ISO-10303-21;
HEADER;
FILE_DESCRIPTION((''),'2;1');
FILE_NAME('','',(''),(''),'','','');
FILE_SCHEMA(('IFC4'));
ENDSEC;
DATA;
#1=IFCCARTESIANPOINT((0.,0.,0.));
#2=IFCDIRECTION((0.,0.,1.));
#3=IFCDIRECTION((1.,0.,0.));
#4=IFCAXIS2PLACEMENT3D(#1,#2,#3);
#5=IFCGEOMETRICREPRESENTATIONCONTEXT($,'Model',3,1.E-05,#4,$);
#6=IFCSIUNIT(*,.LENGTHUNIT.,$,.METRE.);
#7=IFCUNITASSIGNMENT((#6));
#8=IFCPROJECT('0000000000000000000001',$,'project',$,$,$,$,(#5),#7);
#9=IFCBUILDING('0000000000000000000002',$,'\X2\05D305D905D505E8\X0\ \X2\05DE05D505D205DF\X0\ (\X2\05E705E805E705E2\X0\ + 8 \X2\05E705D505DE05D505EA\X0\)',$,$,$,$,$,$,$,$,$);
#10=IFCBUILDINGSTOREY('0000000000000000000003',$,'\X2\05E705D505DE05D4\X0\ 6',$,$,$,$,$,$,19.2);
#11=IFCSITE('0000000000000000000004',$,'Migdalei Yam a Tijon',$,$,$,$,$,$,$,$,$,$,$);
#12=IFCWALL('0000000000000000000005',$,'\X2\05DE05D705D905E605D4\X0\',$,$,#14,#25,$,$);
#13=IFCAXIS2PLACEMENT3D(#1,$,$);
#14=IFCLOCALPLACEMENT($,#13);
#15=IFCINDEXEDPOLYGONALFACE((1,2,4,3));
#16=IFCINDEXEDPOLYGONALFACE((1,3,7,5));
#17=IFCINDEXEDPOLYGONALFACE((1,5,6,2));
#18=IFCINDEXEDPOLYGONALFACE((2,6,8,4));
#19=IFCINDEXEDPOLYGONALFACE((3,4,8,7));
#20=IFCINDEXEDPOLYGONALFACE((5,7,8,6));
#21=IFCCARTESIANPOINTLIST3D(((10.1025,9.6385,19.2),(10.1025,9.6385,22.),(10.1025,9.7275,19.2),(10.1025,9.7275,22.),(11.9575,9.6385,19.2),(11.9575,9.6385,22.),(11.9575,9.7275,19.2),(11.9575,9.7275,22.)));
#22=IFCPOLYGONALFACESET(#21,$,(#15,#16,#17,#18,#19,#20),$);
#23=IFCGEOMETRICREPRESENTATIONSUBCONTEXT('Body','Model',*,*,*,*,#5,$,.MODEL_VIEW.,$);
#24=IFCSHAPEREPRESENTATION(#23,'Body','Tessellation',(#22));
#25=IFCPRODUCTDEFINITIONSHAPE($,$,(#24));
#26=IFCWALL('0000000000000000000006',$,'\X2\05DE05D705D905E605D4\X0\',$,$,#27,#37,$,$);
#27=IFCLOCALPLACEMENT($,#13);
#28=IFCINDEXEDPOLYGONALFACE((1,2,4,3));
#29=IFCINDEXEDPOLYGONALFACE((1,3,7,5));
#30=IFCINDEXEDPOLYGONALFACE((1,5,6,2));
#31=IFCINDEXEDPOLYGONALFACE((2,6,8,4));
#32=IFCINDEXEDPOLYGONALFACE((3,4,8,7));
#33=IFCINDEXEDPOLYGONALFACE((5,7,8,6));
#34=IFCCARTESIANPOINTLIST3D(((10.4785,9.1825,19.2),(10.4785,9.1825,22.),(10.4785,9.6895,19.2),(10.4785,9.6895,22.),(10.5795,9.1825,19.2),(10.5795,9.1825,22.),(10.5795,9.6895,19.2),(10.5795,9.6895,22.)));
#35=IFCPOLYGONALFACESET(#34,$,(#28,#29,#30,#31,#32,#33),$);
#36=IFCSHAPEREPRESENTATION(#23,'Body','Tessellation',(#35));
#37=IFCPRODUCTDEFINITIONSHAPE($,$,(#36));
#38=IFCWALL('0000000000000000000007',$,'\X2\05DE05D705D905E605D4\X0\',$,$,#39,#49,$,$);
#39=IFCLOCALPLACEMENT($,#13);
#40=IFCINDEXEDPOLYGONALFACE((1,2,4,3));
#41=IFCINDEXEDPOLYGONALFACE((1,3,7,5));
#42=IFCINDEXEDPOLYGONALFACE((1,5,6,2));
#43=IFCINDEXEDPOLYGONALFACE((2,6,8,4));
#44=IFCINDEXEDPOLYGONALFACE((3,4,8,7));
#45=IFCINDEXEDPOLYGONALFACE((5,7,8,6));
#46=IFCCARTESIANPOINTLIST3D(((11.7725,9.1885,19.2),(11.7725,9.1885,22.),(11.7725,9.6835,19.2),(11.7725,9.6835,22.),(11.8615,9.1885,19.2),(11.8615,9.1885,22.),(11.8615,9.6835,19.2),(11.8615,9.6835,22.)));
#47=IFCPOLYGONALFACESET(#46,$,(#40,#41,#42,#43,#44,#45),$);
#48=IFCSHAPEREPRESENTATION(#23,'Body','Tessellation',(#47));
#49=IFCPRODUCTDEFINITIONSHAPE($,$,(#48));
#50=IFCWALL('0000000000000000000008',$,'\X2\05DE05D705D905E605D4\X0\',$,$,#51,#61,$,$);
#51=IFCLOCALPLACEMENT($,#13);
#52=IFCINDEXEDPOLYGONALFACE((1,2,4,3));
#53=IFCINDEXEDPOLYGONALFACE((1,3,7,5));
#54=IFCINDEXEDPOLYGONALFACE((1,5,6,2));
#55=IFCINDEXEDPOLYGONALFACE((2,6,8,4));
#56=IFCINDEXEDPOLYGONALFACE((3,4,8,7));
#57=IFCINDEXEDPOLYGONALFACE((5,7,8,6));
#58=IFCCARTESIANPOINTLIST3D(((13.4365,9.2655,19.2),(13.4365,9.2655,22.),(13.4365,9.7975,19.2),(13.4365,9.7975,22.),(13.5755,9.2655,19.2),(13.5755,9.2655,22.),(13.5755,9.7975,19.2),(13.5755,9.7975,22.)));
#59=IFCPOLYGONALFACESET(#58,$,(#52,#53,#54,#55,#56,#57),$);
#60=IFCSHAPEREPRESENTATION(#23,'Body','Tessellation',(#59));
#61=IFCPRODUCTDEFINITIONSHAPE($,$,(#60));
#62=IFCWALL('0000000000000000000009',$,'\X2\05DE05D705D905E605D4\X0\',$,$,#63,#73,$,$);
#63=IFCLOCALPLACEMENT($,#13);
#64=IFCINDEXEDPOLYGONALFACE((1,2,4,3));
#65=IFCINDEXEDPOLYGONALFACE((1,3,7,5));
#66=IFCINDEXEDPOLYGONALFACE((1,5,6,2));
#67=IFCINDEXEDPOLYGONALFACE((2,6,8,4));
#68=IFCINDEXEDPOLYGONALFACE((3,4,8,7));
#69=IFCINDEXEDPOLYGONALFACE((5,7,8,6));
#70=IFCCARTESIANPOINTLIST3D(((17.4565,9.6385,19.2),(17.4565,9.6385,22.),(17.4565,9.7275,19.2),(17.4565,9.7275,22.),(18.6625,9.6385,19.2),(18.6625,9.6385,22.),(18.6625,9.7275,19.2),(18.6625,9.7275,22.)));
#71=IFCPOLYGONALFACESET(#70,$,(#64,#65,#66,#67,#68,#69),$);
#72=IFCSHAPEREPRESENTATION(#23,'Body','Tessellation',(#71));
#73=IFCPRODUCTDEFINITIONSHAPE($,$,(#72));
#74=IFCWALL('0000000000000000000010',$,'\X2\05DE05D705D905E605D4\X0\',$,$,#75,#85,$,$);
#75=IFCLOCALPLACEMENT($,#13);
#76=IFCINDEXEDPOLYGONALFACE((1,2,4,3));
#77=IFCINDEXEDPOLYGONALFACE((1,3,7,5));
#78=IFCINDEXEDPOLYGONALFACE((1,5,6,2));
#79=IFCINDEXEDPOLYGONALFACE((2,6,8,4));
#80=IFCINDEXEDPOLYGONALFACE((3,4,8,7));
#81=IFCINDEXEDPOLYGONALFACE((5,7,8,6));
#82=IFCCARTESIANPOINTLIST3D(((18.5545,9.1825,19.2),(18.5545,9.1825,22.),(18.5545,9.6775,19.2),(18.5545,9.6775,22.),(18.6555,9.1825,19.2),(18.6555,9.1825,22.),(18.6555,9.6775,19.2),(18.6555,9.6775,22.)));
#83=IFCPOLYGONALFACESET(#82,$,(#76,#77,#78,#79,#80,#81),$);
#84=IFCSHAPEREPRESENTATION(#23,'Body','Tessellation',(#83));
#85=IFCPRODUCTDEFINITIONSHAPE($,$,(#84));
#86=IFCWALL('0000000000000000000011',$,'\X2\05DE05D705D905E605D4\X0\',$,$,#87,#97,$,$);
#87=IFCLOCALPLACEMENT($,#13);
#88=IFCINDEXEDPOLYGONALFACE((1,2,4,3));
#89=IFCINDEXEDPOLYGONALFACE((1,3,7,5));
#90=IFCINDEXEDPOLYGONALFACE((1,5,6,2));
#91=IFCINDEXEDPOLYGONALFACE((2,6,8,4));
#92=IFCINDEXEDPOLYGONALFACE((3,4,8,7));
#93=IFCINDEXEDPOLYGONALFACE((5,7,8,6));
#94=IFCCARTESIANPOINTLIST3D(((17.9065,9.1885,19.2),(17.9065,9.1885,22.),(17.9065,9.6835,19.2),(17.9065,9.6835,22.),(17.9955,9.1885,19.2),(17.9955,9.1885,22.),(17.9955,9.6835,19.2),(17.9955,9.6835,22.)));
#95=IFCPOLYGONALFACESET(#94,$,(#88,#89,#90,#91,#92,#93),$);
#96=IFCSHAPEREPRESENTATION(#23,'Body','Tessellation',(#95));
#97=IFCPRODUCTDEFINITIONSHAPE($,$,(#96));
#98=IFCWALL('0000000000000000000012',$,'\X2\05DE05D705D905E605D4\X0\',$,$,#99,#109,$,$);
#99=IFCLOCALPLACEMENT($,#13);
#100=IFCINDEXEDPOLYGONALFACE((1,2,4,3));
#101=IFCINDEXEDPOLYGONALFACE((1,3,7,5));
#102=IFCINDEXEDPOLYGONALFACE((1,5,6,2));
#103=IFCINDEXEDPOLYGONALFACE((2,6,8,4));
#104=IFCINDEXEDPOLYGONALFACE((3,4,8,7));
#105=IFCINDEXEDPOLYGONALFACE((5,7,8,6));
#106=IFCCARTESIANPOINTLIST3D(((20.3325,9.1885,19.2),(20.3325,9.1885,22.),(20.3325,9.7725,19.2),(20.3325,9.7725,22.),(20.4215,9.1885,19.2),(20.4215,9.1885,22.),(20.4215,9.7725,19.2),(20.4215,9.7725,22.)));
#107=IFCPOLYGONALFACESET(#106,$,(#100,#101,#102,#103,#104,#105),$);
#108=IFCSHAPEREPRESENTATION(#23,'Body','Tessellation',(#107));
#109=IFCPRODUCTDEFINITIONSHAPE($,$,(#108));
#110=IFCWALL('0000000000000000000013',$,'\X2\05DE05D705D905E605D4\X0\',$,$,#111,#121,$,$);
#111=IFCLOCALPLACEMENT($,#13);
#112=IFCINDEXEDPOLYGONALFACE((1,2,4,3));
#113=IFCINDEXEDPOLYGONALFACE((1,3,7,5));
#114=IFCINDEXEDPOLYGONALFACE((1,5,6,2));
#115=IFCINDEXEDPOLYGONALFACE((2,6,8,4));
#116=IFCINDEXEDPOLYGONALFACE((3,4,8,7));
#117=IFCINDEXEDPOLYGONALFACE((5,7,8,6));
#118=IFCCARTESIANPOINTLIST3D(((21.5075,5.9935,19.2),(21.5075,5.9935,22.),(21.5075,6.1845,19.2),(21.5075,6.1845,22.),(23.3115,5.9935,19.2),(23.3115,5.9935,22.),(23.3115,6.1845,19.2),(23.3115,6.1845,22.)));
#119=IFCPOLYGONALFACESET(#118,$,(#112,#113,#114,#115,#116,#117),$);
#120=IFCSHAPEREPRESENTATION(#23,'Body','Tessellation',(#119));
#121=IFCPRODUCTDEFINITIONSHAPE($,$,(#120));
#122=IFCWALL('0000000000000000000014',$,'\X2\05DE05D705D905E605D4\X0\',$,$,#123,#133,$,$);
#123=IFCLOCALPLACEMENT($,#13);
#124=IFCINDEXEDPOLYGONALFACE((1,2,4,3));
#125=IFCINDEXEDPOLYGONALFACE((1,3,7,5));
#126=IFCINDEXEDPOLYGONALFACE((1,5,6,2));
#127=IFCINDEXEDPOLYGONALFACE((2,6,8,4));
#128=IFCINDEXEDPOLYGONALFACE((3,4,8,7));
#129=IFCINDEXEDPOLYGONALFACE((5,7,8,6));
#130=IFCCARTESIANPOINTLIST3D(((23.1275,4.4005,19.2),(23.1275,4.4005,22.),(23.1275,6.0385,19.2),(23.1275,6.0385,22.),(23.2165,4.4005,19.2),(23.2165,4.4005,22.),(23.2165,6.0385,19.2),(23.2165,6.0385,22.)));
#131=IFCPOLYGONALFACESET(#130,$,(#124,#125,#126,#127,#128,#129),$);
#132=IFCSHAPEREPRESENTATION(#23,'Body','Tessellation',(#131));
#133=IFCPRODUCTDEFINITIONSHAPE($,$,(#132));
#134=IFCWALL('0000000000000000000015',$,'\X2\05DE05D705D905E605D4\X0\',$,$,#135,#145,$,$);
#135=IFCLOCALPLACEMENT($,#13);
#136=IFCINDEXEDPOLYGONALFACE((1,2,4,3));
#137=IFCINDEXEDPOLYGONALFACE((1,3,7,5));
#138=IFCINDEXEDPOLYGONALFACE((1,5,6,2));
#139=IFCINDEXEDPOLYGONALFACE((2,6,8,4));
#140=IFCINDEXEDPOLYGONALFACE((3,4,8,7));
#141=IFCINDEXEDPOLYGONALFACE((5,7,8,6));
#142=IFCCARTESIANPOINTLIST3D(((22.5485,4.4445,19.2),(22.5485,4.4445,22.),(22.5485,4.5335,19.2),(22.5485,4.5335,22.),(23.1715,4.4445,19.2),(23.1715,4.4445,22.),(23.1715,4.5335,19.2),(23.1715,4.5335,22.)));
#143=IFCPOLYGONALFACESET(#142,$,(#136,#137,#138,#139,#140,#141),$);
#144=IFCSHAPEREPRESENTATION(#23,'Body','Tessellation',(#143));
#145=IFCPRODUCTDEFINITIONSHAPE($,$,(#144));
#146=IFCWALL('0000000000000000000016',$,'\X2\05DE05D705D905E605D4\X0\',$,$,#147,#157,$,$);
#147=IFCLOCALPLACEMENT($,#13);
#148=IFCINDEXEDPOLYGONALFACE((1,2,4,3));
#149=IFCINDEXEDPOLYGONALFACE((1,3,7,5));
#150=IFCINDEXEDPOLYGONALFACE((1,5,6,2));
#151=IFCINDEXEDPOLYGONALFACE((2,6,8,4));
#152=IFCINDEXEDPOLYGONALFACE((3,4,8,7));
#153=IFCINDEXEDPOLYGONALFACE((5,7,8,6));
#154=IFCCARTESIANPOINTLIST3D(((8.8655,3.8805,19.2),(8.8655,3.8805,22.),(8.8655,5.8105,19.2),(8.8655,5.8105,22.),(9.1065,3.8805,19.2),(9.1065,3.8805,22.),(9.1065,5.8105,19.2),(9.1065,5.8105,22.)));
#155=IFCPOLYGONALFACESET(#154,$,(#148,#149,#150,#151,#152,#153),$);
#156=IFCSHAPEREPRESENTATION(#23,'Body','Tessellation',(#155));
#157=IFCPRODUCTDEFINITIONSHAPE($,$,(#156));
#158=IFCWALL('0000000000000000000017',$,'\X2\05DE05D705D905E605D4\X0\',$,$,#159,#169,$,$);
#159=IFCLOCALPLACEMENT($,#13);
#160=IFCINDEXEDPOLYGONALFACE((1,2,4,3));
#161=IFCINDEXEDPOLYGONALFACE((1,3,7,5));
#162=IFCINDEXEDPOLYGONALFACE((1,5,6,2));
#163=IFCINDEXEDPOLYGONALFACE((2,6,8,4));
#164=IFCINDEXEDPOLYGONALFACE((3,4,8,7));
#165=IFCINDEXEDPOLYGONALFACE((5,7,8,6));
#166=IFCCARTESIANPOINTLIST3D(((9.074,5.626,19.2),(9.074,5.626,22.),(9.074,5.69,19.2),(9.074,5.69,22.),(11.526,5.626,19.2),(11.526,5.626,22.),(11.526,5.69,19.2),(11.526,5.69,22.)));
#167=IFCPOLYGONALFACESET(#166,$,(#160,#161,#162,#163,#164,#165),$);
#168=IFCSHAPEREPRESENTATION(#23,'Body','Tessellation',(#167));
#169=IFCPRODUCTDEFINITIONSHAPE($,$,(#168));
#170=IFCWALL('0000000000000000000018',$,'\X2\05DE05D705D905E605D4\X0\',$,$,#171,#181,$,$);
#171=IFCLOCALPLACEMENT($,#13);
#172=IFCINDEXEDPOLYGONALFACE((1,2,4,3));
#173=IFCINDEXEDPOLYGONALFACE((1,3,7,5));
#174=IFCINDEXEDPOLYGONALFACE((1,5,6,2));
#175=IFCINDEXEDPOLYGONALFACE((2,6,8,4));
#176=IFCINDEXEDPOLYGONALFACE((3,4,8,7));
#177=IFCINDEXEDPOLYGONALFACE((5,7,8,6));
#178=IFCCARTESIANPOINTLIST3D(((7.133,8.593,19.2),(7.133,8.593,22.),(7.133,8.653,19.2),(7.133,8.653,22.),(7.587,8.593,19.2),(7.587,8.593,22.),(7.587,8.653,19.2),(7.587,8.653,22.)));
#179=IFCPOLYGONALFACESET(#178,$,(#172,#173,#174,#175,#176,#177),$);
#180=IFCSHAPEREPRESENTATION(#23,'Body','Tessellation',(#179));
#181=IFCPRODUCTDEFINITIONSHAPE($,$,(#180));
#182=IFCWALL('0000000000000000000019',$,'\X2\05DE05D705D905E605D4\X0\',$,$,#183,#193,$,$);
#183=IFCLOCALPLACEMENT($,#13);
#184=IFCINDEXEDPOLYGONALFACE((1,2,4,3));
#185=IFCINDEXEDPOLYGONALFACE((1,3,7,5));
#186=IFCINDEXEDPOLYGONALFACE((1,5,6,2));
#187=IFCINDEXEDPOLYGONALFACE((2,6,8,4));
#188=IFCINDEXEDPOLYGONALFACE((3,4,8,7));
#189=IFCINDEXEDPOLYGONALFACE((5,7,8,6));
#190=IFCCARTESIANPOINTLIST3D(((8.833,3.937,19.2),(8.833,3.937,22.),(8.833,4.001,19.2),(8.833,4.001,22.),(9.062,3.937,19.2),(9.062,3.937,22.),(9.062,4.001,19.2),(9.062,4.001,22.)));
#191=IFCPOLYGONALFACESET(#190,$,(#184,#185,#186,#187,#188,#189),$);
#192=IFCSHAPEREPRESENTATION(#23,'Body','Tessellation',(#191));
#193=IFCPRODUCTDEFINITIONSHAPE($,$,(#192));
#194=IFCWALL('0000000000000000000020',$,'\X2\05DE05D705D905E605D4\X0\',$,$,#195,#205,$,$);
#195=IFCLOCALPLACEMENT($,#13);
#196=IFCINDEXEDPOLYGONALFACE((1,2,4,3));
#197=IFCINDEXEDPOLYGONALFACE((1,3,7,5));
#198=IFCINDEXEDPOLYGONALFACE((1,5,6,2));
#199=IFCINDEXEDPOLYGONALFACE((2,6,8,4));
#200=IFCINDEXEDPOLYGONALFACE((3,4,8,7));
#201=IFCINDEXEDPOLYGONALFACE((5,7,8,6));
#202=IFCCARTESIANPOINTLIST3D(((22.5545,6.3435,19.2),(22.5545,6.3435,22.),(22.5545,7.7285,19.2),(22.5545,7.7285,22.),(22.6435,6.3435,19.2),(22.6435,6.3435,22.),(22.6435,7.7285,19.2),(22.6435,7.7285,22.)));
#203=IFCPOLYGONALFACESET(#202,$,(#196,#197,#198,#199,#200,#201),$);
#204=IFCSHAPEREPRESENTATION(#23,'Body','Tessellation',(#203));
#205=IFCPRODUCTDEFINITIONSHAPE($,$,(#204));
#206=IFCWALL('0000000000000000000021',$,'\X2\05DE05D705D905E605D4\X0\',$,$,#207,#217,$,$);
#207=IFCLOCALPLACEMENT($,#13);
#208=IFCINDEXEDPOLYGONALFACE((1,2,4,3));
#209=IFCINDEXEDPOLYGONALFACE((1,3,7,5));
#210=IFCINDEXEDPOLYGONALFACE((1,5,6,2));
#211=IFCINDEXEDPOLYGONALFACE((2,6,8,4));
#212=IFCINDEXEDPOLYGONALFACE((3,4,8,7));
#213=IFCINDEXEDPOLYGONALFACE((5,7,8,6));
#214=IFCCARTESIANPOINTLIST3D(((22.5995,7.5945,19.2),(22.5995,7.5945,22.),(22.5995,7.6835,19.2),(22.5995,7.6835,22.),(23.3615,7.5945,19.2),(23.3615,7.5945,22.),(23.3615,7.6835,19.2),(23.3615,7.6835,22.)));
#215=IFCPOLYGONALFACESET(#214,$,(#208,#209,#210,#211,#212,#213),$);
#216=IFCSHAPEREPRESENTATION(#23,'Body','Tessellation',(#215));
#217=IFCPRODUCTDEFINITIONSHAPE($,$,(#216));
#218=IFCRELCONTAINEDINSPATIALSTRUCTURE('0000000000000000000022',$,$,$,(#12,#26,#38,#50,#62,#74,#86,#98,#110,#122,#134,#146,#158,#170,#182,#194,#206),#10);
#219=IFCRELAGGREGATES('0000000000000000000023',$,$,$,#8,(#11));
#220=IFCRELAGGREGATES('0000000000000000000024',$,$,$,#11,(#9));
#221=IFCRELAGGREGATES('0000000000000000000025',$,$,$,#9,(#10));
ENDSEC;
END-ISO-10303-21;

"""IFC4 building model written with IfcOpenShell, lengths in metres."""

from ifc_helpers import new_model, si_unit, frame, origin_with_axes, context, subcontext, project, spatial, line, indexed_curve, outline, extrude, element, save


model = new_model("IFC4")

# Units and contexts
model_context = context("Model", 3, precision=1e-05, world=origin_with_axes())
body_context = subcontext(model_context, "Body", "Model", "MODEL_VIEW")
ifc_project = project(units=[si_unit("LENGTHUNIT", "METRE")], contexts=[model_context])

# Site, building, storey
site = spatial("IfcSite", under=ifc_project, Name="Migdalei Yam a Tijon")
building = spatial("IfcBuilding", under=site, Name="דיור מוגן (קרקע + 8 קומות)")
storey = spatial("IfcBuildingStorey", under=building, Name="קומה 6", Elevation=19.2)

# Walls
element("IfcWall", 1, inside=storey, Name="מחיצה", context=body_context, shape_type="SweptSolid", body=[
    extrude(outline(indexed_curve([(0.0, 0.0), (1.855, 0.0), (1.855, 0.089), (0.0, 0.089)], segments=[line(1, 2, 3, 4, 1)])), frame((10.1025, 9.6385, 19.2), z_axis=(0.0, 0.0, 1.0), x_axis=(1.0, 0.0, 0.0)), (0.0, 0.0, 1.0), 2.8),
])
element("IfcWall", 2, inside=storey, Name="מחיצה", context=body_context, shape_type="SweptSolid", body=[
    extrude(outline(indexed_curve([(0.0, 0.0), (0.101, 0.0), (0.101, 0.507), (0.0, 0.507)], segments=[line(1, 2, 3, 4, 1)])), frame((10.4785, 9.1825, 19.2), z_axis=(0.0, 0.0, 1.0), x_axis=(1.0, 0.0, 0.0)), (0.0, 0.0, 1.0), 2.8),
])
element("IfcWall", 3, inside=storey, Name="מחיצה", context=body_context, shape_type="SweptSolid", body=[
    extrude(outline(indexed_curve([(0.0, 0.0), (0.089, 0.0), (0.089, 0.495), (0.0, 0.495)], segments=[line(1, 2, 3, 4, 1)])), frame((11.7725, 9.1885, 19.2), z_axis=(0.0, 0.0, 1.0), x_axis=(1.0, 0.0, 0.0)), (0.0, 0.0, 1.0), 2.8),
])
element("IfcWall", 4, inside=storey, Name="מחיצה", context=body_context, shape_type="SweptSolid", body=[
    extrude(outline(indexed_curve([(0.0, 0.0), (0.139, 0.0), (0.139, 0.532), (0.0, 0.532)], segments=[line(1, 2, 3, 4, 1)])), frame((13.4365, 9.2655, 19.2), z_axis=(0.0, 0.0, 1.0), x_axis=(1.0, 0.0, 0.0)), (0.0, 0.0, 1.0), 2.8),
])
element("IfcWall", 5, inside=storey, Name="מחיצה", context=body_context, shape_type="SweptSolid", body=[
    extrude(outline(indexed_curve([(0.0, 0.0), (1.206, 0.0), (1.206, 0.089), (0.0, 0.089)], segments=[line(1, 2, 3, 4, 1)])), frame((17.4565, 9.6385, 19.2), z_axis=(0.0, 0.0, 1.0), x_axis=(1.0, 0.0, 0.0)), (0.0, 0.0, 1.0), 2.8),
])
element("IfcWall", 6, inside=storey, Name="מחיצה", context=body_context, shape_type="SweptSolid", body=[
    extrude(outline(indexed_curve([(0.0, 0.0), (0.101, 0.0), (0.101, 0.495), (0.0, 0.495)], segments=[line(1, 2, 3, 4, 1)])), frame((18.5545, 9.1825, 19.2), z_axis=(0.0, 0.0, 1.0), x_axis=(1.0, 0.0, 0.0)), (0.0, 0.0, 1.0), 2.8),
])
element("IfcWall", 7, inside=storey, Name="מחיצה", context=body_context, shape_type="SweptSolid", body=[
    extrude(outline(indexed_curve([(0.0, 0.0), (0.089, 0.0), (0.089, 0.495), (0.0, 0.495)], segments=[line(1, 2, 3, 4, 1)])), frame((17.9065, 9.1885, 19.2), z_axis=(0.0, 0.0, 1.0), x_axis=(1.0, 0.0, 0.0)), (0.0, 0.0, 1.0), 2.8),
])
element("IfcWall", 8, inside=storey, Name="מחיצה", context=body_context, shape_type="SweptSolid", body=[
    extrude(outline(indexed_curve([(0.0, 0.0), (0.089, 0.0), (0.089, 0.584), (0.0, 0.584)], segments=[line(1, 2, 3, 4, 1)])), frame((20.3325, 9.1885, 19.2), z_axis=(0.0, 0.0, 1.0), x_axis=(1.0, 0.0, 0.0)), (0.0, 0.0, 1.0), 2.8),
])
element("IfcWall", 9, inside=storey, Name="מחיצה", context=body_context, shape_type="SweptSolid", body=[
    extrude(outline(indexed_curve([(0.0, 0.0), (1.804, 0.0), (1.804, 0.191), (0.0, 0.191)], segments=[line(1, 2, 3, 4, 1)])), frame((21.5075, 5.9935, 19.2), z_axis=(0.0, 0.0, 1.0), x_axis=(1.0, 0.0, 0.0)), (0.0, 0.0, 1.0), 2.8),
])
element("IfcWall", 10, inside=storey, Name="מחיצה", context=body_context, shape_type="SweptSolid", body=[
    extrude(outline(indexed_curve([(0.0, 0.0), (0.089, 0.0), (0.089, 1.638), (0.0, 1.638)], segments=[line(1, 2, 3, 4, 1)])), frame((23.1275, 4.4005, 19.2), z_axis=(0.0, 0.0, 1.0), x_axis=(1.0, 0.0, 0.0)), (0.0, 0.0, 1.0), 2.8),
])
element("IfcWall", 11, inside=storey, Name="מחיצה", context=body_context, shape_type="SweptSolid", body=[
    extrude(outline(indexed_curve([(0.0, 0.0), (0.623, 0.0), (0.623, 0.089), (0.0, 0.089)], segments=[line(1, 2, 3, 4, 1)])), frame((22.5485, 4.4445, 19.2), z_axis=(0.0, 0.0, 1.0), x_axis=(1.0, 0.0, 0.0)), (0.0, 0.0, 1.0), 2.8),
])
element("IfcWall", 12, inside=storey, Name="מחיצה", context=body_context, shape_type="SweptSolid", body=[
    extrude(outline(indexed_curve([(0.0, 0.0), (0.241, 0.0), (0.241, 1.93), (0.0, 1.93)], segments=[line(1, 2, 3, 4, 1)])), frame((8.8655, 3.8805, 19.2), z_axis=(0.0, 0.0, 1.0), x_axis=(1.0, 0.0, 0.0)), (0.0, 0.0, 1.0), 2.8),
])
element("IfcWall", 13, inside=storey, Name="מחיצה", context=body_context, shape_type="SweptSolid", body=[
    extrude(outline(indexed_curve([(0.0, 0.0), (2.452, 0.0), (2.452, 0.064), (0.0, 0.064)], segments=[line(1, 2, 3, 4, 1)])), frame((9.074, 5.626, 19.2), z_axis=(0.0, 0.0, 1.0), x_axis=(1.0, 0.0, 0.0)), (0.0, 0.0, 1.0), 2.8),
])
element("IfcWall", 14, inside=storey, Name="מחיצה", context=body_context, shape_type="SweptSolid", body=[
    extrude(outline(indexed_curve([(0.0, 0.0), (0.454, 0.0), (0.454, 0.06), (0.0, 0.06)], segments=[line(1, 2, 3, 4, 1)])), frame((7.133, 8.593, 19.2), z_axis=(0.0, 0.0, 1.0), x_axis=(1.0, 0.0, 0.0)), (0.0, 0.0, 1.0), 2.8),
])
element("IfcWall", 15, inside=storey, Name="מחיצה", context=body_context, shape_type="SweptSolid", body=[
    extrude(outline(indexed_curve([(0.0, 0.0), (0.229, 0.0), (0.229, 0.064), (0.0, 0.064)], segments=[line(1, 2, 3, 4, 1)])), frame((8.833, 3.937, 19.2), z_axis=(0.0, 0.0, 1.0), x_axis=(1.0, 0.0, 0.0)), (0.0, 0.0, 1.0), 2.8),
])
element("IfcWall", 16, inside=storey, Name="מחיצה", context=body_context, shape_type="SweptSolid", body=[
    extrude(outline(indexed_curve([(0.0, 0.0), (0.089, 0.0), (0.089, 1.385), (0.0, 1.385)], segments=[line(1, 2, 3, 4, 1)])), frame((22.5545, 6.3435, 19.2), z_axis=(0.0, 0.0, 1.0), x_axis=(1.0, 0.0, 0.0)), (0.0, 0.0, 1.0), 2.8),
])
element("IfcWall", 17, inside=storey, Name="מחיצה", context=body_context, shape_type="SweptSolid", body=[
    extrude(outline(indexed_curve([(0.0, 0.0), (0.762, 0.0), (0.762, 0.089), (0.0, 0.089)], segments=[line(1, 2, 3, 4, 1)])), frame((22.5995, 7.5945, 19.2), z_axis=(0.0, 0.0, 1.0), x_axis=(1.0, 0.0, 0.0)), (0.0, 0.0, 1.0), 2.8),
])

save(model, "model.ifc")
